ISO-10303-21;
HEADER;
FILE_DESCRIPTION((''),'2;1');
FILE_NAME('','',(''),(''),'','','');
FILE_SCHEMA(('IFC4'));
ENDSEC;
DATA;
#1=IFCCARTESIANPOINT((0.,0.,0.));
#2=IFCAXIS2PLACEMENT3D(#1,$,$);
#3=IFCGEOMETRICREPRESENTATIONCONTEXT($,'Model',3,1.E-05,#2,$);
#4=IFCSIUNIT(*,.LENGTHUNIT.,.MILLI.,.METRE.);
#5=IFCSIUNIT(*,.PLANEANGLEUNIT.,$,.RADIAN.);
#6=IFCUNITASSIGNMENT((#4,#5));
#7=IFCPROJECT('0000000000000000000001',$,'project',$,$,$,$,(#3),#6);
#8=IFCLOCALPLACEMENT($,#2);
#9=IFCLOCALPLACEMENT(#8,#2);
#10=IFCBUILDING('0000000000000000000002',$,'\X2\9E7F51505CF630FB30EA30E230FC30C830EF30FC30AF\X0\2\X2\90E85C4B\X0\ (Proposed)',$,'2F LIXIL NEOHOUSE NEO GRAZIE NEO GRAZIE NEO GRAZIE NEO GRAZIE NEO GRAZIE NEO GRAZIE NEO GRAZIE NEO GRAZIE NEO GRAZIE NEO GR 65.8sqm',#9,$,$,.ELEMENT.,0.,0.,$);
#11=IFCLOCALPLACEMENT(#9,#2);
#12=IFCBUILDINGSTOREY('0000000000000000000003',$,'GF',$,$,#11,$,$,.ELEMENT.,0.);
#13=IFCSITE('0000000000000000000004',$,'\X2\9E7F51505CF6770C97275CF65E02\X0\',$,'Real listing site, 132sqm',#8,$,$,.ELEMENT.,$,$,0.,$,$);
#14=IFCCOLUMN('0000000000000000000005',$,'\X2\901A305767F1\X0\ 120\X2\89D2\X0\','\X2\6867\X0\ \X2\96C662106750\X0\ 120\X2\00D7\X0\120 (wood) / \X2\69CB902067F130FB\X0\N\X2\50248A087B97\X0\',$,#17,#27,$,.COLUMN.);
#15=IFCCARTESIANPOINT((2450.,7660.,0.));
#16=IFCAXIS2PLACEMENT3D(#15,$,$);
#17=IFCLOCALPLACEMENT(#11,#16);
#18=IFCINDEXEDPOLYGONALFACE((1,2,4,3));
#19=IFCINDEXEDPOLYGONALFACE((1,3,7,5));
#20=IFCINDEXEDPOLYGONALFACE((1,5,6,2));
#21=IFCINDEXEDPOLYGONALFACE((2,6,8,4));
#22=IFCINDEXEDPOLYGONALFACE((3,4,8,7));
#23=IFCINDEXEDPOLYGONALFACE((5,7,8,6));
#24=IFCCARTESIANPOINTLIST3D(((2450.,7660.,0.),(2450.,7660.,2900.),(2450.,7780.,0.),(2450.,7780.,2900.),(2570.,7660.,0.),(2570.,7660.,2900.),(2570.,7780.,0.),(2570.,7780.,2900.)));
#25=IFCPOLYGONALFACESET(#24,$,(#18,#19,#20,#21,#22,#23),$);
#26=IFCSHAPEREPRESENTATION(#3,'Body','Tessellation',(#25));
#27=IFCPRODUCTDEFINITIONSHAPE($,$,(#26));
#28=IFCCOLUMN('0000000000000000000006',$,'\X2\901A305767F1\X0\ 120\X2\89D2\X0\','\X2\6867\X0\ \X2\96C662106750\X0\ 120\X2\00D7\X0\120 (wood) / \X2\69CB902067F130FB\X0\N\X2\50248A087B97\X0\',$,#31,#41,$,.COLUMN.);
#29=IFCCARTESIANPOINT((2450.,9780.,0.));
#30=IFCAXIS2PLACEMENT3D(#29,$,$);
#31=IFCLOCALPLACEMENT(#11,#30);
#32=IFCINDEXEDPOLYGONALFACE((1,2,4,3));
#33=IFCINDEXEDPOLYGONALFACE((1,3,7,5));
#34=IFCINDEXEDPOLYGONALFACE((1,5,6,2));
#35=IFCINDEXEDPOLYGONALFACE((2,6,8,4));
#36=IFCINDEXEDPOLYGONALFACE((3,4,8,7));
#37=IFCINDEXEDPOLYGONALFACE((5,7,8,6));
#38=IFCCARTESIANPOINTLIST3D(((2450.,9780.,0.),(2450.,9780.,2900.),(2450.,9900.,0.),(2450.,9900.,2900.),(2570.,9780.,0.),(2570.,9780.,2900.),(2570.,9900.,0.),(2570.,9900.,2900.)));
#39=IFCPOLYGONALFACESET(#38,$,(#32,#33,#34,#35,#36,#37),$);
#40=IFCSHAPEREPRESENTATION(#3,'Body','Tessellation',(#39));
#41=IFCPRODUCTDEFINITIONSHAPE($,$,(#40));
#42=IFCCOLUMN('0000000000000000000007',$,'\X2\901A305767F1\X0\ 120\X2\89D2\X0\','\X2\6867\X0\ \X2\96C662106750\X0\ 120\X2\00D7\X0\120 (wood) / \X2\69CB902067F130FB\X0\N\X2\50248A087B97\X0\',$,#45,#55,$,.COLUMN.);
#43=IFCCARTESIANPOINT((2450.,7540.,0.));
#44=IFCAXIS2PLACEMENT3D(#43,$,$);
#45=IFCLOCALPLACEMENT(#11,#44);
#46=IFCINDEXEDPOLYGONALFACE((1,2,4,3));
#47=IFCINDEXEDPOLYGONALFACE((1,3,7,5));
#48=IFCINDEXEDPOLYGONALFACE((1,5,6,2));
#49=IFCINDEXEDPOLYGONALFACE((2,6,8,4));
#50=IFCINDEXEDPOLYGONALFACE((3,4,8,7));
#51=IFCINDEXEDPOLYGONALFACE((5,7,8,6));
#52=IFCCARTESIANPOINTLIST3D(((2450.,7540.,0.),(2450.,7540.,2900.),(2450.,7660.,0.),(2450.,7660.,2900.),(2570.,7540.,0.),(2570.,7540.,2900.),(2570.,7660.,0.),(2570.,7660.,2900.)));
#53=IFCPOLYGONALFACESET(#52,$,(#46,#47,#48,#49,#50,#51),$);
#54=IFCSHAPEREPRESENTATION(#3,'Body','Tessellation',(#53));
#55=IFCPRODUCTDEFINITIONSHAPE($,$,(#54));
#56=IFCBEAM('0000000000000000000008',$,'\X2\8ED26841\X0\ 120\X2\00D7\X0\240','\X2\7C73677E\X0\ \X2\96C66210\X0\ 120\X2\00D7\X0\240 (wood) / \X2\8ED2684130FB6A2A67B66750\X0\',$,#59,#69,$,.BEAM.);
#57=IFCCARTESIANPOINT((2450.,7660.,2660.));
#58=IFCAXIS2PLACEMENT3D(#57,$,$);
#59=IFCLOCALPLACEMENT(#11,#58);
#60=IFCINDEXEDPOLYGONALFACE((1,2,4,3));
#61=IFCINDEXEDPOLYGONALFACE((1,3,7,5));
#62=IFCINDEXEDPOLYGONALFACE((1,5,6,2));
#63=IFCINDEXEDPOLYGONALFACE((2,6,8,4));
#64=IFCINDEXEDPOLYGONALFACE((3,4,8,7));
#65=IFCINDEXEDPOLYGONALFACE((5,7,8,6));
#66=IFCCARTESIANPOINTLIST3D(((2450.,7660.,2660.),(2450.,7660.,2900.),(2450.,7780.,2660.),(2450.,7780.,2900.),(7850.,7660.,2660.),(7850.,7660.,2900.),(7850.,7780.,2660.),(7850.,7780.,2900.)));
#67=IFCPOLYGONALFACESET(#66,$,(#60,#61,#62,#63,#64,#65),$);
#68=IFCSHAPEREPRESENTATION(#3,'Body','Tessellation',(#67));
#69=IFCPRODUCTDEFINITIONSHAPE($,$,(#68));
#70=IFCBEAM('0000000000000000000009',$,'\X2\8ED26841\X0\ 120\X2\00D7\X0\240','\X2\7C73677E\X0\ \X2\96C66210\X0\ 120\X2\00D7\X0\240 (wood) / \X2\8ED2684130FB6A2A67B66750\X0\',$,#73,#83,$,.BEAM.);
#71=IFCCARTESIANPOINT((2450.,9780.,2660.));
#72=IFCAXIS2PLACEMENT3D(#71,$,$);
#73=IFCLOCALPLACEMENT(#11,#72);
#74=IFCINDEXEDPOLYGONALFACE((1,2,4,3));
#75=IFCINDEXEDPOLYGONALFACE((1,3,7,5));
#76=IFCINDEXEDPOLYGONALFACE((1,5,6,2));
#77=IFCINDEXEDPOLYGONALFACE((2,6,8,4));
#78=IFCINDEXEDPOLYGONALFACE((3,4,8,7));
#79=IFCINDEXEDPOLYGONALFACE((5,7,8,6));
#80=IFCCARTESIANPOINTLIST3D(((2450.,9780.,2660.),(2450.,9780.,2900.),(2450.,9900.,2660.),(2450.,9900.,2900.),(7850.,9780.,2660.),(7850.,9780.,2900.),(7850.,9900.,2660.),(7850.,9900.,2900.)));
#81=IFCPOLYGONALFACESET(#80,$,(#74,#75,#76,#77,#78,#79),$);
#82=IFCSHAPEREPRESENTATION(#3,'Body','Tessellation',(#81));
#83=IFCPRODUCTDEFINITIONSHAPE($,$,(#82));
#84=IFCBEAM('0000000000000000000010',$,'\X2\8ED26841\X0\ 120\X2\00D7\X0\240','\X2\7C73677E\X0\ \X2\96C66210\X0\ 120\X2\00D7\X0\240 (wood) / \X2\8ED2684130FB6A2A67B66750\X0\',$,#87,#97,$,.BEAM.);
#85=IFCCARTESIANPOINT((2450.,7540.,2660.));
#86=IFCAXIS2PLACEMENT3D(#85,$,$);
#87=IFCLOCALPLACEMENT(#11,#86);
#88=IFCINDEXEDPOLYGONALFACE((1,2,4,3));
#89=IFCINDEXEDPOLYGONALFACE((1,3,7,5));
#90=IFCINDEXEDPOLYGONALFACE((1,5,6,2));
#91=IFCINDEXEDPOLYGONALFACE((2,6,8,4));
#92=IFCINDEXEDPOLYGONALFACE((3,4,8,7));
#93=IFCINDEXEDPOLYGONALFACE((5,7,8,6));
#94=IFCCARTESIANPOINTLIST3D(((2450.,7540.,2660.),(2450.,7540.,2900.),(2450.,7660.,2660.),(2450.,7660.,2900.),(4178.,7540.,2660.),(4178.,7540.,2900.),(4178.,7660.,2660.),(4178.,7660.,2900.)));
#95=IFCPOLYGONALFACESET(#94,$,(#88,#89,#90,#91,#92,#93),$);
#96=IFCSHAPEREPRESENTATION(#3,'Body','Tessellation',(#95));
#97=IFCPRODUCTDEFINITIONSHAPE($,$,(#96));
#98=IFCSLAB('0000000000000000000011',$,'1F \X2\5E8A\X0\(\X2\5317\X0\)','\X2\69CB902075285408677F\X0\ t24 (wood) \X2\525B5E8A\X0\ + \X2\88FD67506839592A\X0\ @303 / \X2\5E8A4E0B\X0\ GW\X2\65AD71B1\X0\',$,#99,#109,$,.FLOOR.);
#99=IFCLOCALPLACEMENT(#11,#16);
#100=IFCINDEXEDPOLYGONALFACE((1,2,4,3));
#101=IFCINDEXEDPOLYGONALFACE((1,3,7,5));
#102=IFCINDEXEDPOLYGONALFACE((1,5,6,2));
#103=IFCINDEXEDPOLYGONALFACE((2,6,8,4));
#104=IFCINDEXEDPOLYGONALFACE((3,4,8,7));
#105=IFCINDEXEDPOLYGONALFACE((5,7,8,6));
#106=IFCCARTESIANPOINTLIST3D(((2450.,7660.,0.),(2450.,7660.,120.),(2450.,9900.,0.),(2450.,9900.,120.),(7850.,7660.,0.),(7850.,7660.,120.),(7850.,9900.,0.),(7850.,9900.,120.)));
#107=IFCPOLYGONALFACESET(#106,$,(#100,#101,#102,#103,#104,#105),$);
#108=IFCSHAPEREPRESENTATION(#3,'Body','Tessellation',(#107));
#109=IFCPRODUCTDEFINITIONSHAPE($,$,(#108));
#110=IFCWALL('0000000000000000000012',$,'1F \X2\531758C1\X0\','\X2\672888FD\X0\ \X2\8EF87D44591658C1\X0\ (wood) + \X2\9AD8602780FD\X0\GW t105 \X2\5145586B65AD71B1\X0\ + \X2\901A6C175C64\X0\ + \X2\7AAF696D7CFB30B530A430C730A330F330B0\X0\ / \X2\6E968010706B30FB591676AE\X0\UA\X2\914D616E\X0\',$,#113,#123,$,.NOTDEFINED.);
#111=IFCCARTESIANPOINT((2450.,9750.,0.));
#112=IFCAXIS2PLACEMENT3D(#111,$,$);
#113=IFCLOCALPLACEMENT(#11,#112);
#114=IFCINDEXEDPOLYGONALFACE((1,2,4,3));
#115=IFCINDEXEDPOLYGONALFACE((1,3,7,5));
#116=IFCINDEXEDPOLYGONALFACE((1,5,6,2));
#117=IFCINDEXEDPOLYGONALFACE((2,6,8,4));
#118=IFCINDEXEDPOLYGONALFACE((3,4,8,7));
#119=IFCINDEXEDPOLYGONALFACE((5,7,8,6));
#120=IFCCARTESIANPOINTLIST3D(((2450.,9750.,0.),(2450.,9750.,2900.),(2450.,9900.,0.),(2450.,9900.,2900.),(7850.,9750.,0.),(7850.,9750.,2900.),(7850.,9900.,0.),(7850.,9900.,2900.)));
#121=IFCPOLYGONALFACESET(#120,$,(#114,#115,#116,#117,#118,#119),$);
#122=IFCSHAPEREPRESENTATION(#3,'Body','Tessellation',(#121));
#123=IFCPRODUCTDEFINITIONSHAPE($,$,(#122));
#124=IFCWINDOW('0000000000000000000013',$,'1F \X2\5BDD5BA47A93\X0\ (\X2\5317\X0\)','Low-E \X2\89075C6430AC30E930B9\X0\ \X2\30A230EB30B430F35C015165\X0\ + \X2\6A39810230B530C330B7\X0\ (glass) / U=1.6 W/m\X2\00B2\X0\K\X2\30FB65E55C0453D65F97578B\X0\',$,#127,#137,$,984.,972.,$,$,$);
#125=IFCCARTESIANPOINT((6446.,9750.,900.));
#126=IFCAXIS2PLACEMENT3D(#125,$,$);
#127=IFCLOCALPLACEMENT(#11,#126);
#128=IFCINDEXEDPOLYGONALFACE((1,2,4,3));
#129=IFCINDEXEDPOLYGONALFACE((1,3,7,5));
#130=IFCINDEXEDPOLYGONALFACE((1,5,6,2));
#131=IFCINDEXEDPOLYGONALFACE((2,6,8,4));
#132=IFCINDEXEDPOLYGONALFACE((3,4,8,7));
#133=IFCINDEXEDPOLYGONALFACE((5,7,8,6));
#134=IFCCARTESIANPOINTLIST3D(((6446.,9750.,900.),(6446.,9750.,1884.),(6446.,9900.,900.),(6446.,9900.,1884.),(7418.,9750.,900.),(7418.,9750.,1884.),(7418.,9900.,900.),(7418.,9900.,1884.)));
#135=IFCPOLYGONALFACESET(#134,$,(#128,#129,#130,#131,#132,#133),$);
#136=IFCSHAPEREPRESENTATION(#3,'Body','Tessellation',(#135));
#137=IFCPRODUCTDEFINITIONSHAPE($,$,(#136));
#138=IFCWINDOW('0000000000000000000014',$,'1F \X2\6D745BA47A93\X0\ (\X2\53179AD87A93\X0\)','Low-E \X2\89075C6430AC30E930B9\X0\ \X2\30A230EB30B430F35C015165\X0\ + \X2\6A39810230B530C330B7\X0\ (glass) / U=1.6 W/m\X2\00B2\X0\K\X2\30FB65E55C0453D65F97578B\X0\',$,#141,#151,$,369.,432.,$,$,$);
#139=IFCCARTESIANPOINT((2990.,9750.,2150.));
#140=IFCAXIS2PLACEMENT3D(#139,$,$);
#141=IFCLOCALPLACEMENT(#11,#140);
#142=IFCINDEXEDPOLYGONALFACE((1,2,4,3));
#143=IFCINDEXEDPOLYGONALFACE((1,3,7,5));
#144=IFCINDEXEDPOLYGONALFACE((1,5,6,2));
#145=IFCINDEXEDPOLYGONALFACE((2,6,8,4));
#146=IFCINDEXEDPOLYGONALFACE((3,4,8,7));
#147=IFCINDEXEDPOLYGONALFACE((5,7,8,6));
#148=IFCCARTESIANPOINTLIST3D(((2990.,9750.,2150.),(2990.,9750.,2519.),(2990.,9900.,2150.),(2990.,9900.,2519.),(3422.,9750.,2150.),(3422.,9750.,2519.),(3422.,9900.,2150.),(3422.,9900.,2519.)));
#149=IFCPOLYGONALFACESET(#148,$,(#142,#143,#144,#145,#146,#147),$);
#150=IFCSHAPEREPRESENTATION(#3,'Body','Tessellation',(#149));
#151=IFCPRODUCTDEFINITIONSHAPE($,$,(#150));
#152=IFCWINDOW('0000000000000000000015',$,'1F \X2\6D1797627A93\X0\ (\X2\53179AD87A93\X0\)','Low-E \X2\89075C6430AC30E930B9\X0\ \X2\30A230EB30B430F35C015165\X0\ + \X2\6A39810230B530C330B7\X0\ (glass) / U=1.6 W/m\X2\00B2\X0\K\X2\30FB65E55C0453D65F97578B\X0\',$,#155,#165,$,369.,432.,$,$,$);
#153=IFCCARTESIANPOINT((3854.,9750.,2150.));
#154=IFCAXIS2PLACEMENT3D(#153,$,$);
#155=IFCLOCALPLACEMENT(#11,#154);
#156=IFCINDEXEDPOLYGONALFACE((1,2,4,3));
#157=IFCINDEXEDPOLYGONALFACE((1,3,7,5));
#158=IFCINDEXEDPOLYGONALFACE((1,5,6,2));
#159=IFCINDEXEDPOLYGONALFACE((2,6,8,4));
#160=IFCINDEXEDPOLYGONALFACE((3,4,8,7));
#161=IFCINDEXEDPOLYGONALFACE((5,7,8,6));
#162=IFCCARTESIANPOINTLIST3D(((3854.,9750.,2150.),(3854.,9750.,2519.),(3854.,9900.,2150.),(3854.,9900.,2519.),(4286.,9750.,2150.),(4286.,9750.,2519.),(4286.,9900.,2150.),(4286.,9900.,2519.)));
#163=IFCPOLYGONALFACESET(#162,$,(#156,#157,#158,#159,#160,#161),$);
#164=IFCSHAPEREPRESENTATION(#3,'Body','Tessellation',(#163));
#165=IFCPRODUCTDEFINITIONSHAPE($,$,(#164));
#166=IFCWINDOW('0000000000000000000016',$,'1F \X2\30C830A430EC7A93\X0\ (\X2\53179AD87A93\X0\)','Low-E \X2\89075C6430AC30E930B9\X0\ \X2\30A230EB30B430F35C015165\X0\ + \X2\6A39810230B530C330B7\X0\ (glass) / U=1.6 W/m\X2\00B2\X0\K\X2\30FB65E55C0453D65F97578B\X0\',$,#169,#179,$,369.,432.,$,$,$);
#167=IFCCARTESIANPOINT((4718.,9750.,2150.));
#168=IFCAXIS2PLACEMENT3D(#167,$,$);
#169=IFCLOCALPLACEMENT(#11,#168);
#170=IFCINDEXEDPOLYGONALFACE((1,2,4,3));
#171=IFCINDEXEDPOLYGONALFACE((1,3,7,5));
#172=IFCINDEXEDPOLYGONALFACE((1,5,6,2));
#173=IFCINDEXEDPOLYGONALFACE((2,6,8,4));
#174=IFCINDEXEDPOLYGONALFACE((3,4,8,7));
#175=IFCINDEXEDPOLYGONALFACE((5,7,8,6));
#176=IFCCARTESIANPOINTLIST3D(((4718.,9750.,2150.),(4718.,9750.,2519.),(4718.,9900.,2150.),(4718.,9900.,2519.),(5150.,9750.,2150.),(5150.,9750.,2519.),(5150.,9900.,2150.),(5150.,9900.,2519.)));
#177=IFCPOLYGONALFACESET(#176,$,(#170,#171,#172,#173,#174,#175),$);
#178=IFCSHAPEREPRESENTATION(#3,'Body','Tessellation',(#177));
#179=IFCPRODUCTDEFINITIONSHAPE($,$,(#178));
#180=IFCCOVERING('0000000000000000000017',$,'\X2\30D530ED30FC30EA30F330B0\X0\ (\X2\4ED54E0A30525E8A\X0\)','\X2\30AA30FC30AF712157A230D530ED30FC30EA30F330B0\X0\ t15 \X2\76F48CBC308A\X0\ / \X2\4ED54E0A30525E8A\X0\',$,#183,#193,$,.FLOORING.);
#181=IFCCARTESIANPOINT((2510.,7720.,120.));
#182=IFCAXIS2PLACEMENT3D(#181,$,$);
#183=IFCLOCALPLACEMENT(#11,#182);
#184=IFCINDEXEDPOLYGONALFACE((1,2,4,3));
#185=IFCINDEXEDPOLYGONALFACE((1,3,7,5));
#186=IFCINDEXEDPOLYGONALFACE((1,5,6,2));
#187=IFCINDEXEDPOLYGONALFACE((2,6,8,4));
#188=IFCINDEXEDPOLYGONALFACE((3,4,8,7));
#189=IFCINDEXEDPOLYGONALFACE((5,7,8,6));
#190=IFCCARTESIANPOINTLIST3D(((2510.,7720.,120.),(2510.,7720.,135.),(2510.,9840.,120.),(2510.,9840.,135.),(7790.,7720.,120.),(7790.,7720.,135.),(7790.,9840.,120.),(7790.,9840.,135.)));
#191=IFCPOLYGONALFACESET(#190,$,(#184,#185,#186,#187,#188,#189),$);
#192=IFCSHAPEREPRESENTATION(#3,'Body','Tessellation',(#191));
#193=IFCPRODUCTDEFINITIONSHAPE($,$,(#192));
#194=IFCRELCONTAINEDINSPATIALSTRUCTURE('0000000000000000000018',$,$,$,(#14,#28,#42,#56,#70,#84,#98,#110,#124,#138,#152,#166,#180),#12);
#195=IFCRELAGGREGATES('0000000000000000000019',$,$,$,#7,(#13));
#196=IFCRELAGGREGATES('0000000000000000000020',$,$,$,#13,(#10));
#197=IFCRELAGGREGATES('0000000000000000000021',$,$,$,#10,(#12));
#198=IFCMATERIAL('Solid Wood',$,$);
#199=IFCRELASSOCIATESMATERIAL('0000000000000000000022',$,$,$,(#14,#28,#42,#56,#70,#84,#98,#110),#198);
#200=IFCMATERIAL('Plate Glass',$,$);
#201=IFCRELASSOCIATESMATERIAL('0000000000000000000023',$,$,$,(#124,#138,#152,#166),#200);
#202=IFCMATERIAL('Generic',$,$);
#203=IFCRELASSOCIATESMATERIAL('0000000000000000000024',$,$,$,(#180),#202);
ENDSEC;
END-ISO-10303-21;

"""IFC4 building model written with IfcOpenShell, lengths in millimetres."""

from ifc_helpers import new_model, si_unit, frame, frame_2d, origin, place, context, project, spatial, rectangle, extrude, material, element, fill, save


model = new_model("IFC4")

# Units and contexts
model_context = context("Model", 3, precision=1e-05, world=origin())
ifc_project = project(units=[si_unit("LENGTHUNIT", "METRE", prefix="MILLI"), si_unit("PLANEANGLEUNIT", "RADIAN")], contexts=[model_context])

# Site, building, storey
site_placement = place(None, origin())
site = spatial("IfcSite", under=ifc_project, at=site_placement, Name="鹿児島県霧島市", ObjectType="Real listing site, 132sqm", CompositionType="ELEMENT", RefElevation=0.0)
building_placement = place(site_placement, origin())
building = spatial("IfcBuilding", under=site, at=building_placement, Name="鹿児島・リモートワーク2部屋 (Proposed)", ObjectType="2F LIXIL NEOHOUSE NEO GRAZIE NEO GRAZIE NEO GRAZIE NEO GRAZIE NEO GRAZIE NEO GRAZIE NEO GRAZIE NEO GRAZIE NEO GRAZIE NEO GR 65.8sqm", CompositionType="ELEMENT", ElevationOfRefHeight=0.0, ElevationOfTerrain=0.0)
storey_placement = place(building_placement, origin())
storey = spatial("IfcBuildingStorey", under=building, at=storey_placement, Name="GF", CompositionType="ELEMENT", Elevation=0.0)

# Columns
ifc_material_1 = material(Name="Solid Wood")
column_1_placement = place(storey_placement, frame((2450.0, 7660.0, 0.0)))
element("IfcColumn", 1, at=column_1_placement, inside=storey, material=ifc_material_1, Name="通し柱 120角", Description="桧 集成材 120×120 (wood) / 構造柱・N値計算", PredefinedType="COLUMN", context=model_context, shape_type="SweptSolid", body=[
    extrude(rectangle(XDim=120.0, YDim=120.0, at=frame_2d((60.0, 60.0))), frame((2450.0, 7660.0, 0.0)), (0.0, 0.0, 1.0), 2900.0),
])
column_2_placement = place(storey_placement, frame((2450.0, 9780.0, 0.0)))
element("IfcColumn", 2, at=column_2_placement, inside=storey, material=ifc_material_1, Name="通し柱 120角", Description="桧 集成材 120×120 (wood) / 構造柱・N値計算", PredefinedType="COLUMN", context=model_context, shape_type="SweptSolid", body=[
    extrude(rectangle(XDim=120.0, YDim=120.0, at=frame_2d((60.0, 60.0))), frame((2450.0, 9780.0, 0.0)), (0.0, 0.0, 1.0), 2900.0),
])
column_3_placement = place(storey_placement, frame((2450.0, 7540.0, 0.0)))
element("IfcColumn", 3, at=column_3_placement, inside=storey, material=ifc_material_1, Name="通し柱 120角", Description="桧 集成材 120×120 (wood) / 構造柱・N値計算", PredefinedType="COLUMN", context=model_context, shape_type="SweptSolid", body=[
    extrude(rectangle(XDim=120.0, YDim=120.0, at=frame_2d((60.0, 60.0))), frame((2450.0, 7540.0, 0.0)), (0.0, 0.0, 1.0), 2900.0),
])

# Beams
beam_1_placement = place(storey_placement, frame((2450.0, 7660.0, 2660.0)))
element("IfcBeam", 4, at=beam_1_placement, inside=storey, material=ifc_material_1, Name="軒桁 120×240", Description="米松 集成 120×240 (wood) / 軒桁・横架材", PredefinedType="BEAM", context=model_context, shape_type="SweptSolid", body=[
    extrude(rectangle(XDim=5400.0, YDim=120.0, at=frame_2d((2700.0, 60.0))), frame((2450.0, 7660.0, 2660.0)), (0.0, 0.0, 1.0), 240.0),
])
beam_2_placement = place(storey_placement, frame((2450.0, 9780.0, 2660.0)))
element("IfcBeam", 5, at=beam_2_placement, inside=storey, material=ifc_material_1, Name="軒桁 120×240", Description="米松 集成 120×240 (wood) / 軒桁・横架材", PredefinedType="BEAM", context=model_context, shape_type="SweptSolid", body=[
    extrude(rectangle(XDim=5400.0, YDim=120.0, at=frame_2d((2700.0, 60.0))), frame((2450.0, 9780.0, 2660.0)), (0.0, 0.0, 1.0), 240.0),
])
beam_3_placement = place(storey_placement, frame((2450.0, 7540.0, 2660.0)))
element("IfcBeam", 6, at=beam_3_placement, inside=storey, material=ifc_material_1, Name="軒桁 120×240", Description="米松 集成 120×240 (wood) / 軒桁・横架材", PredefinedType="BEAM", context=model_context, shape_type="SweptSolid", body=[
    extrude(rectangle(XDim=1728.0, YDim=120.0, at=frame_2d((864.0, 60.0))), frame((2450.0, 7540.0, 2660.0)), (0.0, 0.0, 1.0), 240.0),
])

# Slab
slab_placement = place(storey_placement, frame((2450.0, 7660.0, 0.0)))
element("IfcSlab", 7, at=slab_placement, inside=storey, material=ifc_material_1, Name="1F 床(北)", Description="構造用合板 t24 (wood) 剛床 + 製材根太 @303 / 床下 GW断熱", PredefinedType="FLOOR", context=model_context, shape_type="SweptSolid", body=[
    extrude(rectangle(XDim=5400.0, YDim=2240.0, at=frame_2d((2700.0, 1120.0))), frame((2450.0, 7660.0, 0.0)), (0.0, 0.0, 1.0), 120.0),
])

# Wall, openings, windows
wall_1_placement = place(storey_placement, frame((2450.0, 9750.0, 0.0)))
wall_1 = element("IfcWall", 8, at=wall_1_placement, inside=storey, material=ifc_material_1, Name="1F 北壁", Description="木製 軸組外壁 (wood) + 高性能GW t105 充填断熱 + 通気層 + 窯業系サイディング / 準耐火・外皮UA配慮", PredefinedType="NOTDEFINED", context=model_context, shape_type="SweptSolid", body=[
    extrude(rectangle(XDim=5400.0, YDim=150.0, at=frame_2d((2700.0, 75.0))), frame((2450.0, 9750.0, 0.0)), (0.0, 0.0, 1.0), 2900.0),
])
opening_1_placement = place(storey_placement, frame((6446.0, 9750.0, 900.0)))
opening_1 = element("IfcOpeningElement", 9, at=opening_1_placement, cuts=wall_1, PredefinedType="NOTDEFINED", context=model_context, shape_type="SweptSolid", body=[
    extrude(rectangle(XDim=972.0, YDim=150.0, at=frame_2d((486.0, 75.0))), frame((6446.0, 9750.0, 900.0)), (0.0, 0.0, 1.0), 984.0),
])
opening_2_placement = place(storey_placement, frame((2990.0, 9750.0, 2150.0)))
opening_2 = element("IfcOpeningElement", 10, at=opening_2_placement, cuts=wall_1, PredefinedType="NOTDEFINED", context=model_context, shape_type="SweptSolid", body=[
    extrude(rectangle(XDim=432.0, YDim=150.0, at=frame_2d((216.0, 75.0))), frame((2990.0, 9750.0, 2150.0)), (0.0, 0.0, 1.0), 369.0),
])
opening_3_placement = place(storey_placement, frame((3854.0, 9750.0, 2150.0)))
opening_3 = element("IfcOpeningElement", 11, at=opening_3_placement, cuts=wall_1, PredefinedType="NOTDEFINED", context=model_context, shape_type="SweptSolid", body=[
    extrude(rectangle(XDim=432.0, YDim=150.0, at=frame_2d((216.0, 75.0))), frame((3854.0, 9750.0, 2150.0)), (0.0, 0.0, 1.0), 369.0),
])
opening_4_placement = place(storey_placement, frame((4718.0, 9750.0, 2150.0)))
opening_4 = element("IfcOpeningElement", 12, at=opening_4_placement, cuts=wall_1, PredefinedType="NOTDEFINED", context=model_context, shape_type="SweptSolid", body=[
    extrude(rectangle(XDim=432.0, YDim=150.0, at=frame_2d((216.0, 75.0))), frame((4718.0, 9750.0, 2150.0)), (0.0, 0.0, 1.0), 369.0),
])
ifc_material_2 = material(Name="Plate Glass")
window_1_placement = place(storey_placement, frame((6446.0, 9750.0, 900.0)))
window_1 = element("IfcWindow", 13, at=window_1_placement, inside=storey, material=ifc_material_2, Name="1F 寝室窓 (北)", Description="Low-E 複層ガラス アルゴン封入 + 樹脂サッシ (glass) / U=1.6 W/m²K・日射取得型", OverallHeight=984.0, OverallWidth=972.0, context=model_context, shape_type="SweptSolid", body=[
    extrude(rectangle(XDim=972.0, YDim=150.0, at=frame_2d((486.0, 75.0))), frame((6446.0, 9750.0, 900.0)), (0.0, 0.0, 1.0), 984.0),
])
fill(opening_1, window_1)
window_2_placement = place(storey_placement, frame((2990.0, 9750.0, 2150.0)))
window_2 = element("IfcWindow", 14, at=window_2_placement, inside=storey, material=ifc_material_2, Name="1F 浴室窓 (北高窓)", Description="Low-E 複層ガラス アルゴン封入 + 樹脂サッシ (glass) / U=1.6 W/m²K・日射取得型", OverallHeight=369.0, OverallWidth=432.0, context=model_context, shape_type="SweptSolid", body=[
    extrude(rectangle(XDim=432.0, YDim=150.0, at=frame_2d((216.0, 75.0))), frame((2990.0, 9750.0, 2150.0)), (0.0, 0.0, 1.0), 369.0),
])
fill(opening_2, window_2)
window_3_placement = place(storey_placement, frame((3854.0, 9750.0, 2150.0)))
window_3 = element("IfcWindow", 15, at=window_3_placement, inside=storey, material=ifc_material_2, Name="1F 洗面窓 (北高窓)", Description="Low-E 複層ガラス アルゴン封入 + 樹脂サッシ (glass) / U=1.6 W/m²K・日射取得型", OverallHeight=369.0, OverallWidth=432.0, context=model_context, shape_type="SweptSolid", body=[
    extrude(rectangle(XDim=432.0, YDim=150.0, at=frame_2d((216.0, 75.0))), frame((3854.0, 9750.0, 2150.0)), (0.0, 0.0, 1.0), 369.0),
])
fill(opening_3, window_3)
window_4_placement = place(storey_placement, frame((4718.0, 9750.0, 2150.0)))
window_4 = element("IfcWindow", 16, at=window_4_placement, inside=storey, material=ifc_material_2, Name="1F トイレ窓 (北高窓)", Description="Low-E 複層ガラス アルゴン封入 + 樹脂サッシ (glass) / U=1.6 W/m²K・日射取得型", OverallHeight=369.0, OverallWidth=432.0, context=model_context, shape_type="SweptSolid", body=[
    extrude(rectangle(XDim=432.0, YDim=150.0, at=frame_2d((216.0, 75.0))), frame((4718.0, 9750.0, 2150.0)), (0.0, 0.0, 1.0), 369.0),
])
fill(opening_4, window_4)

# Covering
ifc_material_3 = material(Name="Generic")
covering_1_placement = place(storey_placement, frame((2510.0, 7720.0, 120.0)))
element("IfcCovering", 17, at=covering_1_placement, inside=storey, material=ifc_material_3, Name="フローリング (仕上げ床)", Description="オーク無垢フローリング t15 直貼り / 仕上げ床", PredefinedType="FLOORING", context=model_context, shape_type="SweptSolid", body=[
    extrude(rectangle(XDim=5280.0, YDim=2120.0, at=frame_2d((2640.0, 1060.0))), frame((2510.0, 7720.0, 120.0)), (0.0, 0.0, 1.0), 15.0),
])

save(model, "model.ifc")
